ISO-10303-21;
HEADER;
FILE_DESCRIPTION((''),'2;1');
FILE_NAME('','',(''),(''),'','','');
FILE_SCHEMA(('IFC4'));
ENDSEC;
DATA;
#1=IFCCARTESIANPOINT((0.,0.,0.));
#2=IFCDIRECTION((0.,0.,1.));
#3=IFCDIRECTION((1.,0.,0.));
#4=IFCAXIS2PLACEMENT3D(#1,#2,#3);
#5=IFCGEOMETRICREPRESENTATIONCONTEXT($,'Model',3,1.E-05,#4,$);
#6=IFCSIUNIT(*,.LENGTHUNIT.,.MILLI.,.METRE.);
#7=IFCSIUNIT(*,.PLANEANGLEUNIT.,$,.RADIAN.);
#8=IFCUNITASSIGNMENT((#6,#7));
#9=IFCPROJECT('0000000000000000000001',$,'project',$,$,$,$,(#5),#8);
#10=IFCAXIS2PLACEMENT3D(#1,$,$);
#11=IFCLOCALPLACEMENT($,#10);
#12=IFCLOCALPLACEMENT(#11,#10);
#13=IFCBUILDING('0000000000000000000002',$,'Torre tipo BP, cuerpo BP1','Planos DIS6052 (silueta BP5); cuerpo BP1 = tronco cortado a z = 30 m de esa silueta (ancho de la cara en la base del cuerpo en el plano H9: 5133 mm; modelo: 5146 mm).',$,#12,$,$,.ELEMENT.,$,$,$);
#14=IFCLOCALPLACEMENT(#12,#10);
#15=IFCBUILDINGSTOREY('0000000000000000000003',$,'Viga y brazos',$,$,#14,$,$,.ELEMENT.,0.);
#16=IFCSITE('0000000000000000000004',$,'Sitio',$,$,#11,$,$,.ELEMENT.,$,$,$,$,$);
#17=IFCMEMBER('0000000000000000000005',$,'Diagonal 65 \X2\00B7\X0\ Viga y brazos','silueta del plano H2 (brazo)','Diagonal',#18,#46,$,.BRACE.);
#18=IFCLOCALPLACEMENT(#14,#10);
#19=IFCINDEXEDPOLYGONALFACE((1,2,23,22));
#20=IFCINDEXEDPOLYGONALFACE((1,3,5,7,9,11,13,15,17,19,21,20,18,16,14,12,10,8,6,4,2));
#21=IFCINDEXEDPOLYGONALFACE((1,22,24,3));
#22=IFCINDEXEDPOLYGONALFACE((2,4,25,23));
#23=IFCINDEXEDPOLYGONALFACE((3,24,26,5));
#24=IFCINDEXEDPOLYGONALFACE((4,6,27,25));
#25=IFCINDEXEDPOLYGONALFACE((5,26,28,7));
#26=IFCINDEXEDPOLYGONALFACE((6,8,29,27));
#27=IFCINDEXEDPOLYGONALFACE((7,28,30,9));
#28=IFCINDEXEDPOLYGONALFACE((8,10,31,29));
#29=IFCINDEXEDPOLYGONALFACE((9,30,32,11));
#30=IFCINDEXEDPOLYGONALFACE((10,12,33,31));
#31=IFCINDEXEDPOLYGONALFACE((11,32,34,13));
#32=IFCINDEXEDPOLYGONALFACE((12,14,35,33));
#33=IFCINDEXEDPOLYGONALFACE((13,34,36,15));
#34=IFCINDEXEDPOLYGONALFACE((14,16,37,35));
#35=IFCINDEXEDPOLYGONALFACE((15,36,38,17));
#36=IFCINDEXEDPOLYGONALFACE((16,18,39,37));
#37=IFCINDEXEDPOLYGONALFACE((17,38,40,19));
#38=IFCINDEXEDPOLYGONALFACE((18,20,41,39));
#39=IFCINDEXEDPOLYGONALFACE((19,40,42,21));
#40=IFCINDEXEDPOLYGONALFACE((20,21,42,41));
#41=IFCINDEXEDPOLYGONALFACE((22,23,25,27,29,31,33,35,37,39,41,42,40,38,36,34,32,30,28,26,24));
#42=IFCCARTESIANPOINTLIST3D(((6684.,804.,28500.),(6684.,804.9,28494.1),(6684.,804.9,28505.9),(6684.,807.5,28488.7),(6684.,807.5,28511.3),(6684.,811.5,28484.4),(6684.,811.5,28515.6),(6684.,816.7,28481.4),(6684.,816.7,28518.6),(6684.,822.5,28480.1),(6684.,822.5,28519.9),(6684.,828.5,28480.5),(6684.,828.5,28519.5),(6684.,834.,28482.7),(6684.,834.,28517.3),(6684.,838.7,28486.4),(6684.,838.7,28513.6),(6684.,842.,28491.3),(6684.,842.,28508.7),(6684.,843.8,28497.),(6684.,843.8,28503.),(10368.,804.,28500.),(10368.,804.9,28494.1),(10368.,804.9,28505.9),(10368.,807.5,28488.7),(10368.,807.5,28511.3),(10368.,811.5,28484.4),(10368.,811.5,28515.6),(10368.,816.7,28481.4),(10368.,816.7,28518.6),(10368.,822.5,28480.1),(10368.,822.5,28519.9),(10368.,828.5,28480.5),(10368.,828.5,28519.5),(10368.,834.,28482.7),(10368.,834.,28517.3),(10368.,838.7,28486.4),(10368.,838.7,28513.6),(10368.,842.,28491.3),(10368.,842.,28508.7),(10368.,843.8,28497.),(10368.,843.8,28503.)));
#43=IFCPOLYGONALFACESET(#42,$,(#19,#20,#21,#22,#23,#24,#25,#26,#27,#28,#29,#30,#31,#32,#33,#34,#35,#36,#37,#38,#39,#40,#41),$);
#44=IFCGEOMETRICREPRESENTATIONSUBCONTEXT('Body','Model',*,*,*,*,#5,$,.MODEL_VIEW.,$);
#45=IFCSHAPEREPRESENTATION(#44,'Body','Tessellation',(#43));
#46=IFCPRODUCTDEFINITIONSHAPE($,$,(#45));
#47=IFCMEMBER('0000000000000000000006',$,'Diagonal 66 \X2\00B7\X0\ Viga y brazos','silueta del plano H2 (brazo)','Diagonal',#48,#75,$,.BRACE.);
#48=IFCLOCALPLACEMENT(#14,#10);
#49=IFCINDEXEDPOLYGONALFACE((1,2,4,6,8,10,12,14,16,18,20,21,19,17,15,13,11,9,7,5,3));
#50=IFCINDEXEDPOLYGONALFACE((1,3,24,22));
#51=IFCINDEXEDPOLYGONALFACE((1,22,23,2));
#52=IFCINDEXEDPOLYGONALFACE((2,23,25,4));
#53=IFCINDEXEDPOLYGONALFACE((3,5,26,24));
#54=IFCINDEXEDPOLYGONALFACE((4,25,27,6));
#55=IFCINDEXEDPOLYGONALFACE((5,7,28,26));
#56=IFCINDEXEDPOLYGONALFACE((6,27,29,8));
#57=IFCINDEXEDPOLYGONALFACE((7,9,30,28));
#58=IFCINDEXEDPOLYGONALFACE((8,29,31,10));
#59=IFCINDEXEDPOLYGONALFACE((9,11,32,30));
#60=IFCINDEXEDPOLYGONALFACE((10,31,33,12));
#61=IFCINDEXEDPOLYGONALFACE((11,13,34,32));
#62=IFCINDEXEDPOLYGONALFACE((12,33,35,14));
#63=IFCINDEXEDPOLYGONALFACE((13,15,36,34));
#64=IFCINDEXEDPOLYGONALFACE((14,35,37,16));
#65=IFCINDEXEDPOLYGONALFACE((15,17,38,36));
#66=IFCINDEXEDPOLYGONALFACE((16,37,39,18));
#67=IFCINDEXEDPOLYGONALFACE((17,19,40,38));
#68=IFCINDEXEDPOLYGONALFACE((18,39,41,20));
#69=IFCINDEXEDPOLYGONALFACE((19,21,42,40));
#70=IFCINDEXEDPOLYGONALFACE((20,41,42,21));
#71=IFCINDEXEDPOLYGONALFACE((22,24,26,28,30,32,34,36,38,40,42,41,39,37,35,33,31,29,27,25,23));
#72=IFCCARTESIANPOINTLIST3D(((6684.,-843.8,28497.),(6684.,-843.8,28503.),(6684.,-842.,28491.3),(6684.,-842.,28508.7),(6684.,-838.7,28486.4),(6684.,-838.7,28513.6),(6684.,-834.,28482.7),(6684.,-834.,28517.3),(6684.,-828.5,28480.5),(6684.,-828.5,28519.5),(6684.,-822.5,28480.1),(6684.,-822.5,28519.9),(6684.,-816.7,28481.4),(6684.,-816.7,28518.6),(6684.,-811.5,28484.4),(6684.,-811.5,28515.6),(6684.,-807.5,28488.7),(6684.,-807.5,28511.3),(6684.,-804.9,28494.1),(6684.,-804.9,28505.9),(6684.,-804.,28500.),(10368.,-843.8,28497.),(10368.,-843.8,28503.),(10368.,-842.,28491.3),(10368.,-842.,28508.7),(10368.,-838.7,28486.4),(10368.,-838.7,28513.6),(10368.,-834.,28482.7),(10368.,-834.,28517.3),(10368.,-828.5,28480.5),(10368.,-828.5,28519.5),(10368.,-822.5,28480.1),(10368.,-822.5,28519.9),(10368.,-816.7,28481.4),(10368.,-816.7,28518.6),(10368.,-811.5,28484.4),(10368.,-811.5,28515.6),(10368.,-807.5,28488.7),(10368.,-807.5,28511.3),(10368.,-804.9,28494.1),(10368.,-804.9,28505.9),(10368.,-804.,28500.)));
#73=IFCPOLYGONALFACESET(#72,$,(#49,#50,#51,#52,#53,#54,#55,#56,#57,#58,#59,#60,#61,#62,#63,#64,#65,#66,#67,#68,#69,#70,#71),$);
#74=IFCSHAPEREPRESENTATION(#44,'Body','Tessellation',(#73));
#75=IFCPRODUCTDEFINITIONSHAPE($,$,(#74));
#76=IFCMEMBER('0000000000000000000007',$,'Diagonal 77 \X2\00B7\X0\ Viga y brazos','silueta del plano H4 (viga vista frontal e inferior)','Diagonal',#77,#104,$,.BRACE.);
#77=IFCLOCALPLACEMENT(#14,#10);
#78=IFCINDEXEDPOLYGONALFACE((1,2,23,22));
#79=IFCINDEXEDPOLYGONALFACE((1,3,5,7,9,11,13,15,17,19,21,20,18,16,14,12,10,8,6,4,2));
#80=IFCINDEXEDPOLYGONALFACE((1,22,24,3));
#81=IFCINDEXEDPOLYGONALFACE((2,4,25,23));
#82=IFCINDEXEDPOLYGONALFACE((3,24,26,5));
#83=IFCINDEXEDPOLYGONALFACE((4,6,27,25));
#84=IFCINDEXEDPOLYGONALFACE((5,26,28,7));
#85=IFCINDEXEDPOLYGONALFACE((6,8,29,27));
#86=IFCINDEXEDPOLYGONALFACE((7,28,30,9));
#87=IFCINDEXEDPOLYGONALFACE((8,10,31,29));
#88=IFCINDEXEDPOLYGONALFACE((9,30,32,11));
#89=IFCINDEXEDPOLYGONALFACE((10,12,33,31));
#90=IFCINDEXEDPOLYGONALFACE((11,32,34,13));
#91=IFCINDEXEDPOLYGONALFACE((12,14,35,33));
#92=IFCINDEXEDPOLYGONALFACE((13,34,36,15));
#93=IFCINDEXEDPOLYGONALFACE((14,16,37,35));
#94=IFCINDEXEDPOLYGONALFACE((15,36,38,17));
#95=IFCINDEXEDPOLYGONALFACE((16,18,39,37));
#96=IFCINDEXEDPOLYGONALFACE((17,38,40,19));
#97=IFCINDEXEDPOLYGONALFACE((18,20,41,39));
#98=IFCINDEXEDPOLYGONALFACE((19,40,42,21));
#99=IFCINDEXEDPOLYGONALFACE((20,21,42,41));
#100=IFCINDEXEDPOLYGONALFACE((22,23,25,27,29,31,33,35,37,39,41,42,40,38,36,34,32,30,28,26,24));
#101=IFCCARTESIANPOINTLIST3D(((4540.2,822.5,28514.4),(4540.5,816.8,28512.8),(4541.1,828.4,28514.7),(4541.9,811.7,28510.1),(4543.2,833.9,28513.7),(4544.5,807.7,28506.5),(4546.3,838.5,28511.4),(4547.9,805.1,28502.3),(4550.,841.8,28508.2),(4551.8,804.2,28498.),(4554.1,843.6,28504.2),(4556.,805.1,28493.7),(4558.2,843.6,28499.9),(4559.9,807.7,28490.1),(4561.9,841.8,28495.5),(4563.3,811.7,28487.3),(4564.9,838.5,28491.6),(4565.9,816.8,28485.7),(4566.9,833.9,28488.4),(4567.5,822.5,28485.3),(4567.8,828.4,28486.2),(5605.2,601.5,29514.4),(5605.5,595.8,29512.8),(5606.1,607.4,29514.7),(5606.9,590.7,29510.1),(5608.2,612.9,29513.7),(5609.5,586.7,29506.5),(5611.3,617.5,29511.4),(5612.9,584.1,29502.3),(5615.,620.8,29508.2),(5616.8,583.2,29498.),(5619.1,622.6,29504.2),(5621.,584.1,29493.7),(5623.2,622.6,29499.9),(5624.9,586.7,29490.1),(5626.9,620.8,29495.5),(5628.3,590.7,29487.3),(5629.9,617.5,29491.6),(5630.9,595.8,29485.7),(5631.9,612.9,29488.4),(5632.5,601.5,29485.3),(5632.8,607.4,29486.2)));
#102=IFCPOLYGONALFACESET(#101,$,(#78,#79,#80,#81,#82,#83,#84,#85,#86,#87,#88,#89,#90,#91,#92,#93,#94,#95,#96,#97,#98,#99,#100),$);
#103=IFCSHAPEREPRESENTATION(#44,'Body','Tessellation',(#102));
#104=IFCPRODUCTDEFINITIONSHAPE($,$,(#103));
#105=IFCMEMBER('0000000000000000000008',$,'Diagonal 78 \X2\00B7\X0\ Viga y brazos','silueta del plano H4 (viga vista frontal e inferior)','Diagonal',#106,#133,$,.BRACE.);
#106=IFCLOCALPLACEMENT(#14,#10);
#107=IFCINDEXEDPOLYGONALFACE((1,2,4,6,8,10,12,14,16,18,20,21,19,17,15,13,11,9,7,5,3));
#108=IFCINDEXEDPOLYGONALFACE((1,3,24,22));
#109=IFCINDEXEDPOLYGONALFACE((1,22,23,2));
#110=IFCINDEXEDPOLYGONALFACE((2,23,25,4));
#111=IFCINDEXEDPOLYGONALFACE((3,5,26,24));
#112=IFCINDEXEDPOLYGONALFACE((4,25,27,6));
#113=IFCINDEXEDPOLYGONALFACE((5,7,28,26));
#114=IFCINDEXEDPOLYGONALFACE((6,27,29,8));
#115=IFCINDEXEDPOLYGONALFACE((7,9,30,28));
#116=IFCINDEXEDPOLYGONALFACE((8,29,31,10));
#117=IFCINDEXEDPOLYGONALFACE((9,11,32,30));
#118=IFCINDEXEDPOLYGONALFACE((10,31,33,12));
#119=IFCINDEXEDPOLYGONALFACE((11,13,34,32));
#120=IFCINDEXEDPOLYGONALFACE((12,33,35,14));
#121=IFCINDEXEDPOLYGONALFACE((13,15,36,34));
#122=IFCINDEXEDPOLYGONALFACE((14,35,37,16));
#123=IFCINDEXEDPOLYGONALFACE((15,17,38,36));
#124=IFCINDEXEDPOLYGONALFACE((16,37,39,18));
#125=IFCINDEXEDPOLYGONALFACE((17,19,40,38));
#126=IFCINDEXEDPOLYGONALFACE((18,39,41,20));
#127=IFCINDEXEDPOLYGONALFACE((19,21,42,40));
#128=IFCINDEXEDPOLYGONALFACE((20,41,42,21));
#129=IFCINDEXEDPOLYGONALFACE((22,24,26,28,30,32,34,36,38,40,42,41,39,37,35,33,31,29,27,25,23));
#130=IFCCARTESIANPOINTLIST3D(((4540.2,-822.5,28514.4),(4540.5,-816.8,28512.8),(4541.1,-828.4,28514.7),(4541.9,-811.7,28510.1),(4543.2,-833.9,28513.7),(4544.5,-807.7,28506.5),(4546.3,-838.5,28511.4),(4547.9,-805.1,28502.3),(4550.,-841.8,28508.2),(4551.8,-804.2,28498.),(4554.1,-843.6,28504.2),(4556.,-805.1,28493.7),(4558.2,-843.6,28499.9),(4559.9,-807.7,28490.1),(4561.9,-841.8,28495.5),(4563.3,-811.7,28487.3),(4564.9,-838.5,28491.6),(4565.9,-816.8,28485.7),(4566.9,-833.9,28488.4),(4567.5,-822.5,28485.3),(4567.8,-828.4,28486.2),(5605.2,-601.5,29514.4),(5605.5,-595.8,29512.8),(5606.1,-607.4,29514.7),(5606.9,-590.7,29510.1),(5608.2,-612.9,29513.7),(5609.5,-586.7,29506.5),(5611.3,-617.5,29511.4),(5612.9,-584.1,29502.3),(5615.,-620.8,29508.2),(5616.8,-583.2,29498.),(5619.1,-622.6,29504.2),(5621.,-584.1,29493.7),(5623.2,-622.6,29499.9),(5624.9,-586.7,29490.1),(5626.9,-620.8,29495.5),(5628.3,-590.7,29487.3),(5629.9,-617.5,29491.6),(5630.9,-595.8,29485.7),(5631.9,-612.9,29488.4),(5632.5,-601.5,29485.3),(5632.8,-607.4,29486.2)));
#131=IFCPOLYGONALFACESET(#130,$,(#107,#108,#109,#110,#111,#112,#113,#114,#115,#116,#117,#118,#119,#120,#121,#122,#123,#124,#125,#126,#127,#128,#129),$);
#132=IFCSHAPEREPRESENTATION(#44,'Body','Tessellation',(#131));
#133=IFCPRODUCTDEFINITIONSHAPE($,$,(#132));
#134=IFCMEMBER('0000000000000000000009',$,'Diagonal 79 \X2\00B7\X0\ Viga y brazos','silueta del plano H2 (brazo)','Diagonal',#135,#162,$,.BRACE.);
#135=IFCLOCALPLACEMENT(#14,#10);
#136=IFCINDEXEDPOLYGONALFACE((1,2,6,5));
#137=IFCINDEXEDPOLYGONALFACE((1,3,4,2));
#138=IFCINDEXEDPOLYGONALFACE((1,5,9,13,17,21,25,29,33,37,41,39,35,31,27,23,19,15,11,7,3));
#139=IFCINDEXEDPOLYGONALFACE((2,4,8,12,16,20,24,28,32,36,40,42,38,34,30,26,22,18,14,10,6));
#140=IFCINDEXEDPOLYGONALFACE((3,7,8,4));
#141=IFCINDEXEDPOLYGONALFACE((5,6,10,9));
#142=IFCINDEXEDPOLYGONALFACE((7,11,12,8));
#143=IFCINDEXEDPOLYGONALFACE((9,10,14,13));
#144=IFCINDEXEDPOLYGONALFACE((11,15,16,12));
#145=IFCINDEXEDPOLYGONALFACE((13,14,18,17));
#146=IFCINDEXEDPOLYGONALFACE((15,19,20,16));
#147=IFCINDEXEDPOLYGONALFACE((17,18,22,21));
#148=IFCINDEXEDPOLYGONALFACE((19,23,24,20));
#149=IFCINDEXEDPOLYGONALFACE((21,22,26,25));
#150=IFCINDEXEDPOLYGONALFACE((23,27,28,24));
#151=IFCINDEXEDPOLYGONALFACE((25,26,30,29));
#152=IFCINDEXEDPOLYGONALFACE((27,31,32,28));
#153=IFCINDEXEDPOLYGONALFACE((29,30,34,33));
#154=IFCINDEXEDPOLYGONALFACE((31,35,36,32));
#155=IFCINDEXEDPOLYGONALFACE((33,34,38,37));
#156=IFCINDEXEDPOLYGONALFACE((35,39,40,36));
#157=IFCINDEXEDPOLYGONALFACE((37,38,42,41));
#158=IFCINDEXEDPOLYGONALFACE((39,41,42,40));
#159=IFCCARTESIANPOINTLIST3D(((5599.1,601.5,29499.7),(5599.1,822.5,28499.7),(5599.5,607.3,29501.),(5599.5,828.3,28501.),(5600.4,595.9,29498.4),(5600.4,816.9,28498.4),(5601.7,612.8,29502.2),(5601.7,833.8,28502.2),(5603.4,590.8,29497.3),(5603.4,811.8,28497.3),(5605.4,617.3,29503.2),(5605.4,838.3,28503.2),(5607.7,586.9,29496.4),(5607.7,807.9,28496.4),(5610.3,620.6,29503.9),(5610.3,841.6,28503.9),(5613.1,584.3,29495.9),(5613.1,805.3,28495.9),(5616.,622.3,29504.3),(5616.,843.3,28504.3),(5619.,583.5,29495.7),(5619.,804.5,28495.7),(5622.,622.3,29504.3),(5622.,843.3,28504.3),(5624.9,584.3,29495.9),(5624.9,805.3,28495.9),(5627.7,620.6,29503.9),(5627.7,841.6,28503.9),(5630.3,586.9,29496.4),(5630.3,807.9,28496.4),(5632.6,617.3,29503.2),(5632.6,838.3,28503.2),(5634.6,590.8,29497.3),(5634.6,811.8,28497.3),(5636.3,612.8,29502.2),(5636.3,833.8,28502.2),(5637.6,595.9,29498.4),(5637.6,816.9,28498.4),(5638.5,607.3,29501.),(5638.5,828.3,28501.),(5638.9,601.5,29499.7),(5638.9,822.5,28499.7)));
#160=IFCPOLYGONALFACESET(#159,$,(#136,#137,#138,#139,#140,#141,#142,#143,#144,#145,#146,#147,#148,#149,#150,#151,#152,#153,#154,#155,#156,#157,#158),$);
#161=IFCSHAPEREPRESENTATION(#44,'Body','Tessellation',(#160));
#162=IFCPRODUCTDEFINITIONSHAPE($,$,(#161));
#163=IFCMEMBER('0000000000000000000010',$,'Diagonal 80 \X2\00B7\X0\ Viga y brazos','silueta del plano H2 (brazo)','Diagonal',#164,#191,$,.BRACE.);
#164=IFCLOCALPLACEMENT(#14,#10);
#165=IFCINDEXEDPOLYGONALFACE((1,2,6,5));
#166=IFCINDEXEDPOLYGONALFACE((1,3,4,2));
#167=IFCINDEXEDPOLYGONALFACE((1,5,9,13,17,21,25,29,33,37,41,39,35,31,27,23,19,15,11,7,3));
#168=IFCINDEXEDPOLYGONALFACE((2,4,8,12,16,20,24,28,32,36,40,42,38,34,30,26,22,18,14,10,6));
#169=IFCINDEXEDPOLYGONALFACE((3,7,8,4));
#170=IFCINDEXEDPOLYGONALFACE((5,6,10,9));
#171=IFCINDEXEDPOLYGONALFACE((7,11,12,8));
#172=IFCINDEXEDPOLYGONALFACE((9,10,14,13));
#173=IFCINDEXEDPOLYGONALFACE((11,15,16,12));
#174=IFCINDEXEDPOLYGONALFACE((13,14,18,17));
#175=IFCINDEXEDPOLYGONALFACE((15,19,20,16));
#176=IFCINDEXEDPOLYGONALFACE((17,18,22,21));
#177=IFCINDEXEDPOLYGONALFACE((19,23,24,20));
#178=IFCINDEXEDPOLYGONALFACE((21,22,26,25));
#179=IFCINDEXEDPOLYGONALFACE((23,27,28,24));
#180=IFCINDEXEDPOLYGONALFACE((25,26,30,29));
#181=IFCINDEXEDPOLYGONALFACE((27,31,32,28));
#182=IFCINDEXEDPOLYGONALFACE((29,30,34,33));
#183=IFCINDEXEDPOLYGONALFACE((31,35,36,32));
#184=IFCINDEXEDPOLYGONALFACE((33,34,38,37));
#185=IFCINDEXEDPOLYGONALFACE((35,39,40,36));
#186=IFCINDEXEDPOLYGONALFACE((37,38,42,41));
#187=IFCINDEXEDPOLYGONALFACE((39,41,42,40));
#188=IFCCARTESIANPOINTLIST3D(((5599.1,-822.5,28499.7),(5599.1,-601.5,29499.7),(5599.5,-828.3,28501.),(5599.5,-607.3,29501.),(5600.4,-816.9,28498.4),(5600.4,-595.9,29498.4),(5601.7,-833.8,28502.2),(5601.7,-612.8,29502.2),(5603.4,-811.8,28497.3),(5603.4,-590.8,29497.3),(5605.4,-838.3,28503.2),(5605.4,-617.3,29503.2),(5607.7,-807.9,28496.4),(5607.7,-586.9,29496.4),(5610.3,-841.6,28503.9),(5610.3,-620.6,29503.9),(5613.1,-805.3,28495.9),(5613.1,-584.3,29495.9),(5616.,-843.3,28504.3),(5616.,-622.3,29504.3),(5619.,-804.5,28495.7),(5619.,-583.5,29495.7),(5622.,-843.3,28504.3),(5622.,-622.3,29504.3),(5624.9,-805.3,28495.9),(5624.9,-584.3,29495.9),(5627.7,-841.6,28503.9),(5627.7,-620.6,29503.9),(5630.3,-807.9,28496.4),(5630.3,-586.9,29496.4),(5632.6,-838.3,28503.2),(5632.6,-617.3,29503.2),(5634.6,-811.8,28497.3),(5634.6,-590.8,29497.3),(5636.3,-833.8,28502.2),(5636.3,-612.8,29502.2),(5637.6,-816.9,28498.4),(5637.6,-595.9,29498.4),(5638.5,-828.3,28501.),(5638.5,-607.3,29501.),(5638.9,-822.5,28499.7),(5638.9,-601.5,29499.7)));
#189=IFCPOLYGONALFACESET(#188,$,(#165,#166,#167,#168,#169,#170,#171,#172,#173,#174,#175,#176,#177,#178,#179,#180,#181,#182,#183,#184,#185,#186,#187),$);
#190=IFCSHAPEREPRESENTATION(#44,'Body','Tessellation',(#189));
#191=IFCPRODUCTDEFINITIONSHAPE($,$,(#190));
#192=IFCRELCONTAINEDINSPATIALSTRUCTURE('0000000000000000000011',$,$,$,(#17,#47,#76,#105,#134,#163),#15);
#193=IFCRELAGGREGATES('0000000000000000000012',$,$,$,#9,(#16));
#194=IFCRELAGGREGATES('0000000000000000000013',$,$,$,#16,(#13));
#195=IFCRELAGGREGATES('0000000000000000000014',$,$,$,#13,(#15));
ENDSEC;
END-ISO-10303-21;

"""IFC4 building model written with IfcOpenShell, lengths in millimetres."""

from ifc_helpers import new_model, si_unit, frame, origin, origin_with_axes, place, context, subcontext, project, spatial, circle, extrude, element, save


model = new_model("IFC4")

# Units and contexts
model_context = context("Model", 3, precision=1e-05, world=origin_with_axes())
body_context = subcontext(model_context, "Body", "Model", "MODEL_VIEW")
ifc_project = project(units=[si_unit("LENGTHUNIT", "METRE", prefix="MILLI"), si_unit("PLANEANGLEUNIT", "RADIAN")], contexts=[model_context])

# Site, building, storey
site_placement = place(None, origin())
site = spatial("IfcSite", under=ifc_project, at=site_placement, Name="Sitio", CompositionType="ELEMENT")
building_placement = place(site_placement, origin())
building = spatial("IfcBuilding", under=site, at=building_placement, Name="Torre tipo BP, cuerpo BP1", Description="Planos DIS6052 (silueta BP5); cuerpo BP1 = tronco cortado a z = 30 m de esa silueta (ancho de la cara en la base del cuerpo en el plano H9: 5133 mm; modelo: 5146 mm).", CompositionType="ELEMENT")
storey_placement = place(building_placement, origin())
storey = spatial("IfcBuildingStorey", under=building, at=storey_placement, Name="Viga y brazos", CompositionType="ELEMENT", Elevation=0.0)

# Members
for number, where, z_axis, x_axis, name in (
    (1, (6684.0, 824.0, 28500.0), (1.0, 0.0, 0.0), (0.0, -1.0, 0.0), "Diagonal 65 · Viga y brazos"),
    (2, (6684.0, -824.0, 28500.0), (1.0, 0.0, 0.0), (0.0, 1.0, 0.0), "Diagonal 66 · Viga y brazos"),
):
    element("IfcMember", number, at=place(storey_placement, frame(where, z_axis=z_axis, x_axis=x_axis)), inside=storey, Name=name, Description="silueta del plano H2 (brazo)", ObjectType="Diagonal", PredefinedType="BRACE", context=body_context, shape_type="SweptSolid", body=[
        extrude(circle(Radius=20.0), None, (0.0, 0.0, 1.0), 3684.0),
    ])
for number, where, z_axis, x_axis, name in (
    (3, (4554.0, 824.0, 28500.0), (0.720802, -0.149575, 0.67681), (-0.109041, -0.98875, -0.102386), "Diagonal 77 · Viga y brazos"),
    (4, (4554.0, -824.0, 28500.0), (0.720802, 0.149575, 0.67681), (-0.109041, 0.98875, -0.102386), "Diagonal 78 · Viga y brazos"),
):
    element("IfcMember", number, at=place(storey_placement, frame(where, z_axis=z_axis, x_axis=x_axis)), inside=storey, Name=name, Description="silueta del plano H4 (viga vista frontal e inferior)", ObjectType="Diagonal", PredefinedType="BRACE", context=body_context, shape_type="SweptSolid", body=[
        extrude(circle(Radius=20.0), None, (0.0, 0.0, 1.0), 1477.5),
    ])
for number, where, z_axis, x_axis, name in (
    (5, (5619.0, 824.0, 28500.0), (0.0, -0.215793, 0.976439), (0.0, -0.976439, -0.215793), "Diagonal 79 · Viga y brazos"),
    (6, (5619.0, -824.0, 28500.0), (0.0, 0.215793, 0.976439), (0.0, 0.976439, -0.215793), "Diagonal 80 · Viga y brazos"),
):
    element("IfcMember", number, at=place(storey_placement, frame(where, z_axis=z_axis, x_axis=x_axis)), inside=storey, Name=name, Description="silueta del plano H2 (brazo)", ObjectType="Diagonal", PredefinedType="BRACE", context=body_context, shape_type="SweptSolid", body=[
        extrude(circle(Radius=20.0), None, (0.0, 0.0, 1.0), 1024.1),
    ])

save(model, "model.ifc")
